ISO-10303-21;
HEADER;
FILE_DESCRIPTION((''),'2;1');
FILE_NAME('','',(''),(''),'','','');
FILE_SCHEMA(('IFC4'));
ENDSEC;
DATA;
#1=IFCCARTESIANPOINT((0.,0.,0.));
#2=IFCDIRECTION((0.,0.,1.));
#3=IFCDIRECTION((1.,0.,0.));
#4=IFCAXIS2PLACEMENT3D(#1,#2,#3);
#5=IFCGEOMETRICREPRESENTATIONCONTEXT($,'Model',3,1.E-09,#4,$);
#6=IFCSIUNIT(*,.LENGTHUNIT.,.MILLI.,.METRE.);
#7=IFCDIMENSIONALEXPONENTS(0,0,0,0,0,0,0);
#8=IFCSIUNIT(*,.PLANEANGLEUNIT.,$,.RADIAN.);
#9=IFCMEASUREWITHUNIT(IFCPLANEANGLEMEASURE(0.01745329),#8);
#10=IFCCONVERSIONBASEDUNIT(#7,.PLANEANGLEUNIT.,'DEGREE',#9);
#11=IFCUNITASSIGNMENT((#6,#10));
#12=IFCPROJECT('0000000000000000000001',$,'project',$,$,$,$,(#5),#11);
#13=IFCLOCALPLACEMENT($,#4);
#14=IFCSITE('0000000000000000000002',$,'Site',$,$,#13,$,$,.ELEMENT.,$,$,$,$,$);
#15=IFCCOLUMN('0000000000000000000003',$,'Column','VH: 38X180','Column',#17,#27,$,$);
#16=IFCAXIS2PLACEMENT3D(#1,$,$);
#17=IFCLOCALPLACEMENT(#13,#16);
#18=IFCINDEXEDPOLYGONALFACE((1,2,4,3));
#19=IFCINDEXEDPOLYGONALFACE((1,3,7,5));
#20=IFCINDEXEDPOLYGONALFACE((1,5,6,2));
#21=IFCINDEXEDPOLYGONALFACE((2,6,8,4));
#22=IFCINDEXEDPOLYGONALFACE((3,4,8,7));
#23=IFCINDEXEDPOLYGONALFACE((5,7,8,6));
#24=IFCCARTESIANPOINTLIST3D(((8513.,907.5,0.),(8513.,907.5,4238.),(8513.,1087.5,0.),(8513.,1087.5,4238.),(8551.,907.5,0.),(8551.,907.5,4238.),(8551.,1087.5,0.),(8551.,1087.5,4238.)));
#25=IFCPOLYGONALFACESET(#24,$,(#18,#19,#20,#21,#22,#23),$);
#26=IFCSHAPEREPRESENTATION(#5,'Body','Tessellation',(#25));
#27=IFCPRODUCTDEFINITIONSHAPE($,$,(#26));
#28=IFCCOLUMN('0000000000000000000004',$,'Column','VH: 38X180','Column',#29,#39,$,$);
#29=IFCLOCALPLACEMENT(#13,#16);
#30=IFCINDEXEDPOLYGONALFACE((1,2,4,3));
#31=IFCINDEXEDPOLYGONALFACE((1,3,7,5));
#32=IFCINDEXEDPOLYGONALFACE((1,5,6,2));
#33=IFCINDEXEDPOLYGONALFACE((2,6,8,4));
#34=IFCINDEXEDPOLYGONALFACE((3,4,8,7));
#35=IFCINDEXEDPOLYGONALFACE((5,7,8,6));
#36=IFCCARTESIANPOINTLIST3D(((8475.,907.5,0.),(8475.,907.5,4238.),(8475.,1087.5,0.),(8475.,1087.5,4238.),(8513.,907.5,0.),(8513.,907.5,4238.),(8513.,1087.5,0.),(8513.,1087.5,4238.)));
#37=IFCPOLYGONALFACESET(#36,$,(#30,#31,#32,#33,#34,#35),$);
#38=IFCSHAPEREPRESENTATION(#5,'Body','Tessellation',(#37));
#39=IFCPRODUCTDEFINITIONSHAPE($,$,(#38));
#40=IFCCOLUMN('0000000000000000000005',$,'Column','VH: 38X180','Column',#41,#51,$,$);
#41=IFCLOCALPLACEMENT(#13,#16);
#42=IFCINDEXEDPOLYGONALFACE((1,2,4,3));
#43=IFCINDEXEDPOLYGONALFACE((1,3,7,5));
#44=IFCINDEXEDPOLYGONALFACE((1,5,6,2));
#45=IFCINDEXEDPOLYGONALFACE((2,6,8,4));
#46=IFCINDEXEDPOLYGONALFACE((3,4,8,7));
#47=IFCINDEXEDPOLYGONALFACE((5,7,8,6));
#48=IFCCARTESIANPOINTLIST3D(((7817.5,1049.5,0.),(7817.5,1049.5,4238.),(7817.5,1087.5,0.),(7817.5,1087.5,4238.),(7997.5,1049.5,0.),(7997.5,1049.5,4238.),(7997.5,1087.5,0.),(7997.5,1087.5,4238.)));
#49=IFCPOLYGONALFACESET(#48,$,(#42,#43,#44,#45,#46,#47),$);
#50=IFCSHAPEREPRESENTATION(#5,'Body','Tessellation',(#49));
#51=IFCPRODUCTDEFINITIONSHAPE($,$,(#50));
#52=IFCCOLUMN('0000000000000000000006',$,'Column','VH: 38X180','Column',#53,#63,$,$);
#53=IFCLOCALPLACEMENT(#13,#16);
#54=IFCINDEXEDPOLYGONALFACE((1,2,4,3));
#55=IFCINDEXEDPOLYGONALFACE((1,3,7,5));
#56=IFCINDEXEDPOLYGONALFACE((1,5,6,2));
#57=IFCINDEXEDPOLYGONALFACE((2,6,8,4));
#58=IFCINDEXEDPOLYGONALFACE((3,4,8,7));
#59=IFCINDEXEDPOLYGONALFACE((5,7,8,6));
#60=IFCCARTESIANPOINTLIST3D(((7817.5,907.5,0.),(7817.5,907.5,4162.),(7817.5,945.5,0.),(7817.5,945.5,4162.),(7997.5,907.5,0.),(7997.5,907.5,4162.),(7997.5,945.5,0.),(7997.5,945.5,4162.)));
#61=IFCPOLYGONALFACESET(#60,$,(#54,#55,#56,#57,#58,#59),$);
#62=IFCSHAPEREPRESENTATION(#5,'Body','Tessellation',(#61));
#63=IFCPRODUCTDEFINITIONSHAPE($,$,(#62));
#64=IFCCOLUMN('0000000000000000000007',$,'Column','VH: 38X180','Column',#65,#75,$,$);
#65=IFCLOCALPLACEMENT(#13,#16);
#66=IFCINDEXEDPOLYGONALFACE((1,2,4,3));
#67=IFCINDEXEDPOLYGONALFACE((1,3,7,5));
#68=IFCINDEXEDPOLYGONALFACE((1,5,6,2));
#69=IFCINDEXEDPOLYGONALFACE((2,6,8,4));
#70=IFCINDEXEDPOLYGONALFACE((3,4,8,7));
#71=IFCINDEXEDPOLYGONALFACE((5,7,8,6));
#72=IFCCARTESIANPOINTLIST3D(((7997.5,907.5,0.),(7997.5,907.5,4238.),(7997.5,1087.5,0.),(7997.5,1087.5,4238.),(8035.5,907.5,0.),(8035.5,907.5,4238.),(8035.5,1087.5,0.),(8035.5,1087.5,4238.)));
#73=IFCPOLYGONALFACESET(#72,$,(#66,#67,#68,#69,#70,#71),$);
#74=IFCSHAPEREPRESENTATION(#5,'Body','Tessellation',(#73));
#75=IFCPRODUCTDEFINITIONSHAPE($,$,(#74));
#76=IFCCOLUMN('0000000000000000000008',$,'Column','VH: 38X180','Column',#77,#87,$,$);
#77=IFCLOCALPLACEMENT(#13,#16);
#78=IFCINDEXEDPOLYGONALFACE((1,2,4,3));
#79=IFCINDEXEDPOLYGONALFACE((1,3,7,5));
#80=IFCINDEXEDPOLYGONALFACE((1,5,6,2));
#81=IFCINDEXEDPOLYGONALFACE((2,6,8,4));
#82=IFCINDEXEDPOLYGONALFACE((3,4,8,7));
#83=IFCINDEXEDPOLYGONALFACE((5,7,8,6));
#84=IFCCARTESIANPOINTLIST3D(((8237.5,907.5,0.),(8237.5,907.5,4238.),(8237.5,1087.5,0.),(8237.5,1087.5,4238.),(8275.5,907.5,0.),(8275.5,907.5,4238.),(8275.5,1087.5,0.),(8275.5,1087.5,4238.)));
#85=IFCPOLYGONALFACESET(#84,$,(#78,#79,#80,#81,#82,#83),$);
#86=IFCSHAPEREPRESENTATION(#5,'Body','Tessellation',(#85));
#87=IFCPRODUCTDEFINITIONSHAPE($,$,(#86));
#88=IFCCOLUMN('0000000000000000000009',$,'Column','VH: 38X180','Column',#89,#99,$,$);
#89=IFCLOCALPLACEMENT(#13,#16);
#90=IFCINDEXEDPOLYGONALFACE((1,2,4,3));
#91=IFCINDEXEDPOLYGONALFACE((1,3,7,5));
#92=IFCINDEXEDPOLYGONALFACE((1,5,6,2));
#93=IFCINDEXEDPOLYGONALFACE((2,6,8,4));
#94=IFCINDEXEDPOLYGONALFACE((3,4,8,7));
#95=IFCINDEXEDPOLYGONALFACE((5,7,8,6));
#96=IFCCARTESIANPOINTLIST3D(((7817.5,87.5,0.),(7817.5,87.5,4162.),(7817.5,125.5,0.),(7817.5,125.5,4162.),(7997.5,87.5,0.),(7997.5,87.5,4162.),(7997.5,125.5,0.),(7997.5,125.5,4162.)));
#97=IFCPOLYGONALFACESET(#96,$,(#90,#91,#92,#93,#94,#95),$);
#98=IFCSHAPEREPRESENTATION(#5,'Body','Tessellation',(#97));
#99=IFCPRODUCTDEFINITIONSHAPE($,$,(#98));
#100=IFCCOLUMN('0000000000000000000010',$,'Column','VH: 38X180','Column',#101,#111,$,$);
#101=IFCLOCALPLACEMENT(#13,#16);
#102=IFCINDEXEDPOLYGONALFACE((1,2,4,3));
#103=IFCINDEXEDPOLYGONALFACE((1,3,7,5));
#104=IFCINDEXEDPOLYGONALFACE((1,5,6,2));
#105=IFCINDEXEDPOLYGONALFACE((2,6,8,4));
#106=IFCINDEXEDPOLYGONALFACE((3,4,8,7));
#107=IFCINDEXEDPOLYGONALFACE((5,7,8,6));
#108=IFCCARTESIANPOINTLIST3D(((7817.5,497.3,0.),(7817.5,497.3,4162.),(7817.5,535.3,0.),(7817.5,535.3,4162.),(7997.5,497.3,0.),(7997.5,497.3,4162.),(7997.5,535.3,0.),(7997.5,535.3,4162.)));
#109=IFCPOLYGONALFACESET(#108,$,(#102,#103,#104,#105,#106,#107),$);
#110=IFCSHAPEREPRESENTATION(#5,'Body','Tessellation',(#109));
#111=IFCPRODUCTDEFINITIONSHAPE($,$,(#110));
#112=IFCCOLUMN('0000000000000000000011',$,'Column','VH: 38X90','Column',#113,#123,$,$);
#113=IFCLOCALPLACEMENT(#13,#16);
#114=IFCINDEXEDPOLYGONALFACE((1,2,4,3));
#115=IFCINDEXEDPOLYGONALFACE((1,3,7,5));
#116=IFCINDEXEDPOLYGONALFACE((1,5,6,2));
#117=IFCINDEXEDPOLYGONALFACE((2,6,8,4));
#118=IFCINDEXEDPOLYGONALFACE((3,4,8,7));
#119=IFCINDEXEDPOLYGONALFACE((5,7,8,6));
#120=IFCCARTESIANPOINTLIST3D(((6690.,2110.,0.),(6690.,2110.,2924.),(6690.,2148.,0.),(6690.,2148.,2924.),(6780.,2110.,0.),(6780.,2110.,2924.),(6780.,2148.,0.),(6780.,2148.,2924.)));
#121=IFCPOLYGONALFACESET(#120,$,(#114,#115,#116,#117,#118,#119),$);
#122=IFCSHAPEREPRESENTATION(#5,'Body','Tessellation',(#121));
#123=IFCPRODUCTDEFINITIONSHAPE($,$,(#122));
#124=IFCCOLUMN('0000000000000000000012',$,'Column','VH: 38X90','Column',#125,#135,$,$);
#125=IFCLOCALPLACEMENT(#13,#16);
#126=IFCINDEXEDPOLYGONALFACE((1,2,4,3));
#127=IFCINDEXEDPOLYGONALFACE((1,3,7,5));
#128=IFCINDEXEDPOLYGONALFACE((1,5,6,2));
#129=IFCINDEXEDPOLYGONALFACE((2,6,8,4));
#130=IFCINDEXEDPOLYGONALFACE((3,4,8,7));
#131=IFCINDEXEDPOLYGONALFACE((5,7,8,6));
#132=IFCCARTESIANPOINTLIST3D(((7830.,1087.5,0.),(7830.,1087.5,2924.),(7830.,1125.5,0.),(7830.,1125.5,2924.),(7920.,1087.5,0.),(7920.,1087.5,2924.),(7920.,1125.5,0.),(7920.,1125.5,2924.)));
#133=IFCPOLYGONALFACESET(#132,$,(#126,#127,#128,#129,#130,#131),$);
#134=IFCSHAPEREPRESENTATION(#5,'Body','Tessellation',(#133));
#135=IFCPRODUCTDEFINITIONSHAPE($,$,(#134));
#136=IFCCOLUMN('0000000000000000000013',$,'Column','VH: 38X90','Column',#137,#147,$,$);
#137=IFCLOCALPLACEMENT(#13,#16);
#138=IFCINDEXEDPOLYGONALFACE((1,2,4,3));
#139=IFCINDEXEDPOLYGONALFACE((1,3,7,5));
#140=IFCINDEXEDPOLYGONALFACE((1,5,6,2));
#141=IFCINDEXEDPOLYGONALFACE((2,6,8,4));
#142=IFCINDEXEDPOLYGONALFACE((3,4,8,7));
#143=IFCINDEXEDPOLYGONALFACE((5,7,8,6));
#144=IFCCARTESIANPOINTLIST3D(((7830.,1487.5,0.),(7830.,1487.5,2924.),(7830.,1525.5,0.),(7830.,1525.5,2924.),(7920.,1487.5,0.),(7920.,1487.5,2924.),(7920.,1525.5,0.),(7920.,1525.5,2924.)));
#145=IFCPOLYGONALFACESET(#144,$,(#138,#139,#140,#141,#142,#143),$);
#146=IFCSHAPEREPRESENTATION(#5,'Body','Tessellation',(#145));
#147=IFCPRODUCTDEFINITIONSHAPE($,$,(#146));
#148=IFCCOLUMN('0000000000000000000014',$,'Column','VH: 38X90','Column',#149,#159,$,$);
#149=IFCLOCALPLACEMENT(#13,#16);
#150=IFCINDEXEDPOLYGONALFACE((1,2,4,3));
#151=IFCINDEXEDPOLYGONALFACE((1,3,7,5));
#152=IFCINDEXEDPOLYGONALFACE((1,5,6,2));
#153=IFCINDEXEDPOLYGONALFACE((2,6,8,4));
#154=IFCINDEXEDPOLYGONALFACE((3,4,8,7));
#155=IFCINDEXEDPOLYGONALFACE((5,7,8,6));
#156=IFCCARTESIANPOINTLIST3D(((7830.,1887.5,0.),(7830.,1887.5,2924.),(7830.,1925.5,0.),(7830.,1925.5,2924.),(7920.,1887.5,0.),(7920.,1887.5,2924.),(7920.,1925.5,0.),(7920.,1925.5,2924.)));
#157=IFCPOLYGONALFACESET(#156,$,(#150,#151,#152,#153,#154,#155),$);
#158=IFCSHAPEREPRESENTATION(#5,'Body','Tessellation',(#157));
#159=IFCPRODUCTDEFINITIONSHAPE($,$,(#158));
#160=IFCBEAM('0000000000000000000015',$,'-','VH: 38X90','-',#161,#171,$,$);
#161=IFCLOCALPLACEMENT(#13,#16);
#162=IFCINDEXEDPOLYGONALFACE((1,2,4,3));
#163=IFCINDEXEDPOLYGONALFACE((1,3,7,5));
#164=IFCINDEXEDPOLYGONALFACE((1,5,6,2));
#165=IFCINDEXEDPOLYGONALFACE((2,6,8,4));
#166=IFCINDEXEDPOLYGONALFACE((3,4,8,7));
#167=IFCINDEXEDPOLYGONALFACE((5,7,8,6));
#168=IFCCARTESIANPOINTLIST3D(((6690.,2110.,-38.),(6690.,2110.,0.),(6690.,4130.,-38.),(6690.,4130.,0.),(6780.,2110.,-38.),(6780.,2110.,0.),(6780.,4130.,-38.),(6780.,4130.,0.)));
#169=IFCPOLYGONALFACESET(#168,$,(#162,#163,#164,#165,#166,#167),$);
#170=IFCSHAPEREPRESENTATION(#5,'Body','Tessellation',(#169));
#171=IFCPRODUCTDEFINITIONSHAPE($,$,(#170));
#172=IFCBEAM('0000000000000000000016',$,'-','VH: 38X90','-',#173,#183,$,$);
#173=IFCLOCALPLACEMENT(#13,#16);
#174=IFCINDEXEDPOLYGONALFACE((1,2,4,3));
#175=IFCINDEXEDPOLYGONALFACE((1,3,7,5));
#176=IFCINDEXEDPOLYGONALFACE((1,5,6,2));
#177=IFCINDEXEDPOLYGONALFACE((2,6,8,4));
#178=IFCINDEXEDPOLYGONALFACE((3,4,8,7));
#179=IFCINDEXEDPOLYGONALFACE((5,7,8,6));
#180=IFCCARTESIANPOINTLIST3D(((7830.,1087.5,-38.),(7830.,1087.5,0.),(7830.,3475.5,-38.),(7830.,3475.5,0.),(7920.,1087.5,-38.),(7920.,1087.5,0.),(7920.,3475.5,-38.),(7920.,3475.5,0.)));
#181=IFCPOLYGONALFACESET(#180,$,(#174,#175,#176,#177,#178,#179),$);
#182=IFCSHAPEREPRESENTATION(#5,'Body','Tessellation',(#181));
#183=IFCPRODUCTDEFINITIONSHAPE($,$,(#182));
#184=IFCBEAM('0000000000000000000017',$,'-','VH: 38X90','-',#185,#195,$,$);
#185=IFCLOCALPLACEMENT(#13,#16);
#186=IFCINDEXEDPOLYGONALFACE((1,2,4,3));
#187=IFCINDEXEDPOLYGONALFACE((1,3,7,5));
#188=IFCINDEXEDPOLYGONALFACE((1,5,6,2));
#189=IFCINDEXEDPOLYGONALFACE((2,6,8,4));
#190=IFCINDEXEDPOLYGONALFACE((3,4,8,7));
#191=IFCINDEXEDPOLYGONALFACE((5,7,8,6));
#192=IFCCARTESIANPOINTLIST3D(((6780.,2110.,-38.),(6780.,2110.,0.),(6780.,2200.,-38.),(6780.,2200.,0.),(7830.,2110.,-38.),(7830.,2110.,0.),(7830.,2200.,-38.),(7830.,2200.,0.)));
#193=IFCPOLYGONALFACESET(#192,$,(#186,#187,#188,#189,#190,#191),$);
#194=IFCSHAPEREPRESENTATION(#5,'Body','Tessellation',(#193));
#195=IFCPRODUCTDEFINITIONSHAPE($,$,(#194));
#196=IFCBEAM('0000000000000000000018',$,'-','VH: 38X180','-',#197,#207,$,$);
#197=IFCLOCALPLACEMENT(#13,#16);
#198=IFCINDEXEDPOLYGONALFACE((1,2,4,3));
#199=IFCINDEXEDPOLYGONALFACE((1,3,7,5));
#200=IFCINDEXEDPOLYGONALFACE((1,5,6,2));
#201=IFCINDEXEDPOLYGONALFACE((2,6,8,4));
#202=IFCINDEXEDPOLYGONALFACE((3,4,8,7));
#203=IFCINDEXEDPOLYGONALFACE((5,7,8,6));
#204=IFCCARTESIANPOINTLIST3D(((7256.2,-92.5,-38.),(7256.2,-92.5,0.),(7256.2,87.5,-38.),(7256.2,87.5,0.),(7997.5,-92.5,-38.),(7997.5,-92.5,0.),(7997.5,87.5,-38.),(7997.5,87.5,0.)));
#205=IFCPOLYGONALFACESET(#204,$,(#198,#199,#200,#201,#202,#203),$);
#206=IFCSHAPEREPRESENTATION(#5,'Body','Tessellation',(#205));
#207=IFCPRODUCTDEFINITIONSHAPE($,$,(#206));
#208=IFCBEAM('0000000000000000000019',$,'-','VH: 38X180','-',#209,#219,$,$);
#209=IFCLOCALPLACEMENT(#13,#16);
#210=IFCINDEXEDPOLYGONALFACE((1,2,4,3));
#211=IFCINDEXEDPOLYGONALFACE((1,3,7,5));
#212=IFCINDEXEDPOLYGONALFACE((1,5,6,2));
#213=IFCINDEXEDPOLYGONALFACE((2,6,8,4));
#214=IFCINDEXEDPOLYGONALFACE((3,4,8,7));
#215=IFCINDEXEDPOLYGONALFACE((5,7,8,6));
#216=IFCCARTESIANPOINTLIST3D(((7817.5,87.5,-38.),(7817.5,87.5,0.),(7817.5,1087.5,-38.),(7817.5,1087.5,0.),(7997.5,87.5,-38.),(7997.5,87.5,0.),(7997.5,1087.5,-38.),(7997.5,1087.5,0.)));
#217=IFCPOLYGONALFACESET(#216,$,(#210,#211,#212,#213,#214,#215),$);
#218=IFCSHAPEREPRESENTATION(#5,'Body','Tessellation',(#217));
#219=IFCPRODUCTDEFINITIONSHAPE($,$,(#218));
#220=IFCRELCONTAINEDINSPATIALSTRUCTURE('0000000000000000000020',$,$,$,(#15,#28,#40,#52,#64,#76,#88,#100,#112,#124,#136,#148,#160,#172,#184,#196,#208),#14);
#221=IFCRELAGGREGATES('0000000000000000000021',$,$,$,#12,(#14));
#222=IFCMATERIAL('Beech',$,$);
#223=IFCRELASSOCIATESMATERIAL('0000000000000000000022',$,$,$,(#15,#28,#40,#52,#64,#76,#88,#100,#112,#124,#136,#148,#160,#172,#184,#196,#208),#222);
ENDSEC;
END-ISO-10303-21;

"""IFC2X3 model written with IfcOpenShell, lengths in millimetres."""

from ifc_helpers import new_model, entity, si_unit, converted_unit, frame, origin, origin_with_axes, origin_2d, place, context, project, spatial, rectangle, extrude, material, element, save


model = new_model("IFC2X3")

# Units and contexts
model_context = context("Model", 3, precision=1e-09, world=origin_with_axes())
ifc_project = project(units=[si_unit("LENGTHUNIT", "METRE", prefix="MILLI"), converted_unit("PLANEANGLEUNIT", "DEGREE", entity("IfcPlaneAngleMeasure", 0.01745329), si_unit("PLANEANGLEUNIT", "RADIAN"), dimensions=[0, 0, 0, 0, 0, 0, 0])], contexts=[model_context])

# Site
site_placement = place(None, origin_with_axes())
site = spatial("IfcSite", under=ifc_project, at=site_placement, Name="Site", CompositionType="ELEMENT")

# Columns
ifc_material = material(Name="Beech")
for number, where, z_axis, x_axis, name in (
    (1, (8532.0, 997.5, 0.0), (0.0, 0.0, -1.0), (-1.0, 0.0, 0.0), "Column"),
    (2, (8494.0, 997.5, 0.0), (0.0, 0.0, -1.0), (-1.0, 0.0, 0.0), "Column"),
    (3, (7907.5, 1068.5, 0.0), (0.0, 0.0, -1.0), (0.0, -1.0, 0.0), "Column"),
):
    element("IfcColumn", number, at=place(None, frame(where, z_axis=z_axis, x_axis=x_axis)), inside=site, material=ifc_material, Name=name, Description="VH: 38X180", ObjectType="Column", context=model_context, shape_type="SweptSolid", body=[
        extrude(rectangle(XDim=38.0, YDim=180.0, at=origin_2d()), origin(), (0.0, 0.0, -1.0), 4238.0),
    ])
column_1_placement = place(None, frame((7907.5, 926.5, 0.0), z_axis=(0.0, 0.0, -1.0), x_axis=(0.0, -1.0, 0.0)))
element("IfcColumn", 4, at=column_1_placement, inside=site, material=ifc_material, Name="Column", Description="VH: 38X180", ObjectType="Column", context=model_context, shape_type="SweptSolid", body=[
    extrude(rectangle(XDim=38.0, YDim=180.0, at=origin_2d()), origin(), (0.0, 0.0, -1.0), 4162.0),
])
for number, where, z_axis, x_axis, name in (
    (5, (8016.5, 997.5, 0.0), (0.0, 0.0, -1.0), (-1.0, 0.0, 0.0), "Column"),
    (6, (8256.5, 997.5, 0.0), (0.0, 0.0, -1.0), (-1.0, 0.0, 0.0), "Column"),
):
    element("IfcColumn", number, at=place(None, frame(where, z_axis=z_axis, x_axis=x_axis)), inside=site, material=ifc_material, Name=name, Description="VH: 38X180", ObjectType="Column", context=model_context, shape_type="SweptSolid", body=[
        extrude(rectangle(XDim=38.0, YDim=180.0, at=origin_2d()), origin(), (0.0, 0.0, -1.0), 4238.0),
    ])
column_2_placement = place(None, frame((7907.5, 106.5, 0.0), z_axis=(0.0, 0.0, -1.0), x_axis=(0.0, -1.0, 0.0)))
element("IfcColumn", 7, at=column_2_placement, inside=site, material=ifc_material, Name="Column", Description="VH: 38X180", ObjectType="Column", context=model_context, shape_type="SweptSolid", body=[
    extrude(rectangle(XDim=38.0, YDim=180.0, at=origin_2d()), origin(), (0.0, 0.0, -1.0), 4162.0),
])
column_3_placement = place(None, frame((7907.5, 516.3, 0.0), z_axis=(0.0, 0.0, -1.0), x_axis=(0.0, -1.0, 0.0)))
element("IfcColumn", 8, at=column_3_placement, inside=site, material=ifc_material, Name="Column", Description="VH: 38X180", ObjectType="Column", context=model_context, shape_type="SweptSolid", body=[
    extrude(rectangle(XDim=38.0, YDim=180.0, at=origin_2d()), origin(), (0.0, 0.0, -1.0), 4162.0),
])
for number, where, z_axis, x_axis, name in (
    (9, (6735.0, 2129.0, 0.0), (0.0, 0.0, -1.0), (0.0, -1.0, 0.0), "Column"),
    (10, (7875.0, 1106.5, 0.0), (0.0, 0.0, -1.0), (0.0, -1.0, 0.0), "Column"),
    (11, (7875.0, 1506.5, 0.0), (0.0, 0.0, -1.0), (0.0, -1.0, 0.0), "Column"),
    (12, (7875.0, 1906.5, 0.0), (0.0, 0.0, -1.0), (0.0, -1.0, 0.0), "Column"),
):
    element("IfcColumn", number, at=place(None, frame(where, z_axis=z_axis, x_axis=x_axis)), inside=site, material=ifc_material, Name=name, Description="VH: 38X90", ObjectType="Column", context=model_context, shape_type="SweptSolid", body=[
        extrude(rectangle(XDim=38.0, YDim=90.0, at=origin_2d()), origin(), (0.0, 0.0, -1.0), 2924.0),
    ])

# Beams
beam_1_placement = place(None, frame((6735.0, 2110.0, -19.0), z_axis=(0.0, -1.0, 0.0), x_axis=(0.0, 0.0, -1.0)))
element("IfcBeam", 13, at=beam_1_placement, inside=site, material=ifc_material, Name="-", Description="VH: 38X90", ObjectType="-", context=model_context, shape_type="SweptSolid", body=[
    extrude(rectangle(XDim=38.0, YDim=90.0, at=origin_2d()), origin(), (0.0, 0.0, -1.0), 2020.0),
])
beam_2_placement = place(None, frame((7875.0, 1087.5, -19.0), z_axis=(0.0, -1.0, 0.0), x_axis=(0.0, 0.0, -1.0)))
element("IfcBeam", 14, at=beam_2_placement, inside=site, material=ifc_material, Name="-", Description="VH: 38X90", ObjectType="-", context=model_context, shape_type="SweptSolid", body=[
    extrude(rectangle(XDim=38.0, YDim=90.0, at=origin_2d()), origin(), (0.0, 0.0, -1.0), 2388.0),
])
beam_3_placement = place(None, frame((6780.0, 2155.0, -19.0), z_axis=(-1.0, 0.0, 0.0), x_axis=(0.0, 0.0, -1.0)))
element("IfcBeam", 15, at=beam_3_placement, inside=site, material=ifc_material, Name="-", Description="VH: 38X90", ObjectType="-", context=model_context, shape_type="SweptSolid", body=[
    extrude(rectangle(XDim=38.0, YDim=90.0, at=origin_2d()), origin(), (0.0, 0.0, -1.0), 1050.0),
])
beam_4_placement = place(None, frame((7997.5, -2.5, -19.0), z_axis=(1.0, -0.000003, 0.0), x_axis=(0.0, 0.0, -1.0)))
element("IfcBeam", 16, at=beam_4_placement, inside=site, material=ifc_material, Name="-", Description="VH: 38X180", ObjectType="-", context=model_context, shape_type="SweptSolid", body=[
    extrude(rectangle(XDim=38.0, YDim=180.0, at=origin_2d()), origin(), (0.0, 0.0, -1.0), 741.3),
])
beam_5_placement = place(None, frame((7907.5, 1087.5, -19.0), z_axis=(0.000013, -1.0, 0.0), x_axis=(0.0, 0.0, 1.0)))
element("IfcBeam", 17, at=beam_5_placement, inside=site, material=ifc_material, Name="-", Description="VH: 38X180", ObjectType="-", context=model_context, shape_type="SweptSolid", body=[
    extrude(rectangle(XDim=38.0, YDim=180.0, at=origin_2d()), origin(), (0.0, 0.0, 1.0), 1000.0),
])

save(model, "model.ifc")
